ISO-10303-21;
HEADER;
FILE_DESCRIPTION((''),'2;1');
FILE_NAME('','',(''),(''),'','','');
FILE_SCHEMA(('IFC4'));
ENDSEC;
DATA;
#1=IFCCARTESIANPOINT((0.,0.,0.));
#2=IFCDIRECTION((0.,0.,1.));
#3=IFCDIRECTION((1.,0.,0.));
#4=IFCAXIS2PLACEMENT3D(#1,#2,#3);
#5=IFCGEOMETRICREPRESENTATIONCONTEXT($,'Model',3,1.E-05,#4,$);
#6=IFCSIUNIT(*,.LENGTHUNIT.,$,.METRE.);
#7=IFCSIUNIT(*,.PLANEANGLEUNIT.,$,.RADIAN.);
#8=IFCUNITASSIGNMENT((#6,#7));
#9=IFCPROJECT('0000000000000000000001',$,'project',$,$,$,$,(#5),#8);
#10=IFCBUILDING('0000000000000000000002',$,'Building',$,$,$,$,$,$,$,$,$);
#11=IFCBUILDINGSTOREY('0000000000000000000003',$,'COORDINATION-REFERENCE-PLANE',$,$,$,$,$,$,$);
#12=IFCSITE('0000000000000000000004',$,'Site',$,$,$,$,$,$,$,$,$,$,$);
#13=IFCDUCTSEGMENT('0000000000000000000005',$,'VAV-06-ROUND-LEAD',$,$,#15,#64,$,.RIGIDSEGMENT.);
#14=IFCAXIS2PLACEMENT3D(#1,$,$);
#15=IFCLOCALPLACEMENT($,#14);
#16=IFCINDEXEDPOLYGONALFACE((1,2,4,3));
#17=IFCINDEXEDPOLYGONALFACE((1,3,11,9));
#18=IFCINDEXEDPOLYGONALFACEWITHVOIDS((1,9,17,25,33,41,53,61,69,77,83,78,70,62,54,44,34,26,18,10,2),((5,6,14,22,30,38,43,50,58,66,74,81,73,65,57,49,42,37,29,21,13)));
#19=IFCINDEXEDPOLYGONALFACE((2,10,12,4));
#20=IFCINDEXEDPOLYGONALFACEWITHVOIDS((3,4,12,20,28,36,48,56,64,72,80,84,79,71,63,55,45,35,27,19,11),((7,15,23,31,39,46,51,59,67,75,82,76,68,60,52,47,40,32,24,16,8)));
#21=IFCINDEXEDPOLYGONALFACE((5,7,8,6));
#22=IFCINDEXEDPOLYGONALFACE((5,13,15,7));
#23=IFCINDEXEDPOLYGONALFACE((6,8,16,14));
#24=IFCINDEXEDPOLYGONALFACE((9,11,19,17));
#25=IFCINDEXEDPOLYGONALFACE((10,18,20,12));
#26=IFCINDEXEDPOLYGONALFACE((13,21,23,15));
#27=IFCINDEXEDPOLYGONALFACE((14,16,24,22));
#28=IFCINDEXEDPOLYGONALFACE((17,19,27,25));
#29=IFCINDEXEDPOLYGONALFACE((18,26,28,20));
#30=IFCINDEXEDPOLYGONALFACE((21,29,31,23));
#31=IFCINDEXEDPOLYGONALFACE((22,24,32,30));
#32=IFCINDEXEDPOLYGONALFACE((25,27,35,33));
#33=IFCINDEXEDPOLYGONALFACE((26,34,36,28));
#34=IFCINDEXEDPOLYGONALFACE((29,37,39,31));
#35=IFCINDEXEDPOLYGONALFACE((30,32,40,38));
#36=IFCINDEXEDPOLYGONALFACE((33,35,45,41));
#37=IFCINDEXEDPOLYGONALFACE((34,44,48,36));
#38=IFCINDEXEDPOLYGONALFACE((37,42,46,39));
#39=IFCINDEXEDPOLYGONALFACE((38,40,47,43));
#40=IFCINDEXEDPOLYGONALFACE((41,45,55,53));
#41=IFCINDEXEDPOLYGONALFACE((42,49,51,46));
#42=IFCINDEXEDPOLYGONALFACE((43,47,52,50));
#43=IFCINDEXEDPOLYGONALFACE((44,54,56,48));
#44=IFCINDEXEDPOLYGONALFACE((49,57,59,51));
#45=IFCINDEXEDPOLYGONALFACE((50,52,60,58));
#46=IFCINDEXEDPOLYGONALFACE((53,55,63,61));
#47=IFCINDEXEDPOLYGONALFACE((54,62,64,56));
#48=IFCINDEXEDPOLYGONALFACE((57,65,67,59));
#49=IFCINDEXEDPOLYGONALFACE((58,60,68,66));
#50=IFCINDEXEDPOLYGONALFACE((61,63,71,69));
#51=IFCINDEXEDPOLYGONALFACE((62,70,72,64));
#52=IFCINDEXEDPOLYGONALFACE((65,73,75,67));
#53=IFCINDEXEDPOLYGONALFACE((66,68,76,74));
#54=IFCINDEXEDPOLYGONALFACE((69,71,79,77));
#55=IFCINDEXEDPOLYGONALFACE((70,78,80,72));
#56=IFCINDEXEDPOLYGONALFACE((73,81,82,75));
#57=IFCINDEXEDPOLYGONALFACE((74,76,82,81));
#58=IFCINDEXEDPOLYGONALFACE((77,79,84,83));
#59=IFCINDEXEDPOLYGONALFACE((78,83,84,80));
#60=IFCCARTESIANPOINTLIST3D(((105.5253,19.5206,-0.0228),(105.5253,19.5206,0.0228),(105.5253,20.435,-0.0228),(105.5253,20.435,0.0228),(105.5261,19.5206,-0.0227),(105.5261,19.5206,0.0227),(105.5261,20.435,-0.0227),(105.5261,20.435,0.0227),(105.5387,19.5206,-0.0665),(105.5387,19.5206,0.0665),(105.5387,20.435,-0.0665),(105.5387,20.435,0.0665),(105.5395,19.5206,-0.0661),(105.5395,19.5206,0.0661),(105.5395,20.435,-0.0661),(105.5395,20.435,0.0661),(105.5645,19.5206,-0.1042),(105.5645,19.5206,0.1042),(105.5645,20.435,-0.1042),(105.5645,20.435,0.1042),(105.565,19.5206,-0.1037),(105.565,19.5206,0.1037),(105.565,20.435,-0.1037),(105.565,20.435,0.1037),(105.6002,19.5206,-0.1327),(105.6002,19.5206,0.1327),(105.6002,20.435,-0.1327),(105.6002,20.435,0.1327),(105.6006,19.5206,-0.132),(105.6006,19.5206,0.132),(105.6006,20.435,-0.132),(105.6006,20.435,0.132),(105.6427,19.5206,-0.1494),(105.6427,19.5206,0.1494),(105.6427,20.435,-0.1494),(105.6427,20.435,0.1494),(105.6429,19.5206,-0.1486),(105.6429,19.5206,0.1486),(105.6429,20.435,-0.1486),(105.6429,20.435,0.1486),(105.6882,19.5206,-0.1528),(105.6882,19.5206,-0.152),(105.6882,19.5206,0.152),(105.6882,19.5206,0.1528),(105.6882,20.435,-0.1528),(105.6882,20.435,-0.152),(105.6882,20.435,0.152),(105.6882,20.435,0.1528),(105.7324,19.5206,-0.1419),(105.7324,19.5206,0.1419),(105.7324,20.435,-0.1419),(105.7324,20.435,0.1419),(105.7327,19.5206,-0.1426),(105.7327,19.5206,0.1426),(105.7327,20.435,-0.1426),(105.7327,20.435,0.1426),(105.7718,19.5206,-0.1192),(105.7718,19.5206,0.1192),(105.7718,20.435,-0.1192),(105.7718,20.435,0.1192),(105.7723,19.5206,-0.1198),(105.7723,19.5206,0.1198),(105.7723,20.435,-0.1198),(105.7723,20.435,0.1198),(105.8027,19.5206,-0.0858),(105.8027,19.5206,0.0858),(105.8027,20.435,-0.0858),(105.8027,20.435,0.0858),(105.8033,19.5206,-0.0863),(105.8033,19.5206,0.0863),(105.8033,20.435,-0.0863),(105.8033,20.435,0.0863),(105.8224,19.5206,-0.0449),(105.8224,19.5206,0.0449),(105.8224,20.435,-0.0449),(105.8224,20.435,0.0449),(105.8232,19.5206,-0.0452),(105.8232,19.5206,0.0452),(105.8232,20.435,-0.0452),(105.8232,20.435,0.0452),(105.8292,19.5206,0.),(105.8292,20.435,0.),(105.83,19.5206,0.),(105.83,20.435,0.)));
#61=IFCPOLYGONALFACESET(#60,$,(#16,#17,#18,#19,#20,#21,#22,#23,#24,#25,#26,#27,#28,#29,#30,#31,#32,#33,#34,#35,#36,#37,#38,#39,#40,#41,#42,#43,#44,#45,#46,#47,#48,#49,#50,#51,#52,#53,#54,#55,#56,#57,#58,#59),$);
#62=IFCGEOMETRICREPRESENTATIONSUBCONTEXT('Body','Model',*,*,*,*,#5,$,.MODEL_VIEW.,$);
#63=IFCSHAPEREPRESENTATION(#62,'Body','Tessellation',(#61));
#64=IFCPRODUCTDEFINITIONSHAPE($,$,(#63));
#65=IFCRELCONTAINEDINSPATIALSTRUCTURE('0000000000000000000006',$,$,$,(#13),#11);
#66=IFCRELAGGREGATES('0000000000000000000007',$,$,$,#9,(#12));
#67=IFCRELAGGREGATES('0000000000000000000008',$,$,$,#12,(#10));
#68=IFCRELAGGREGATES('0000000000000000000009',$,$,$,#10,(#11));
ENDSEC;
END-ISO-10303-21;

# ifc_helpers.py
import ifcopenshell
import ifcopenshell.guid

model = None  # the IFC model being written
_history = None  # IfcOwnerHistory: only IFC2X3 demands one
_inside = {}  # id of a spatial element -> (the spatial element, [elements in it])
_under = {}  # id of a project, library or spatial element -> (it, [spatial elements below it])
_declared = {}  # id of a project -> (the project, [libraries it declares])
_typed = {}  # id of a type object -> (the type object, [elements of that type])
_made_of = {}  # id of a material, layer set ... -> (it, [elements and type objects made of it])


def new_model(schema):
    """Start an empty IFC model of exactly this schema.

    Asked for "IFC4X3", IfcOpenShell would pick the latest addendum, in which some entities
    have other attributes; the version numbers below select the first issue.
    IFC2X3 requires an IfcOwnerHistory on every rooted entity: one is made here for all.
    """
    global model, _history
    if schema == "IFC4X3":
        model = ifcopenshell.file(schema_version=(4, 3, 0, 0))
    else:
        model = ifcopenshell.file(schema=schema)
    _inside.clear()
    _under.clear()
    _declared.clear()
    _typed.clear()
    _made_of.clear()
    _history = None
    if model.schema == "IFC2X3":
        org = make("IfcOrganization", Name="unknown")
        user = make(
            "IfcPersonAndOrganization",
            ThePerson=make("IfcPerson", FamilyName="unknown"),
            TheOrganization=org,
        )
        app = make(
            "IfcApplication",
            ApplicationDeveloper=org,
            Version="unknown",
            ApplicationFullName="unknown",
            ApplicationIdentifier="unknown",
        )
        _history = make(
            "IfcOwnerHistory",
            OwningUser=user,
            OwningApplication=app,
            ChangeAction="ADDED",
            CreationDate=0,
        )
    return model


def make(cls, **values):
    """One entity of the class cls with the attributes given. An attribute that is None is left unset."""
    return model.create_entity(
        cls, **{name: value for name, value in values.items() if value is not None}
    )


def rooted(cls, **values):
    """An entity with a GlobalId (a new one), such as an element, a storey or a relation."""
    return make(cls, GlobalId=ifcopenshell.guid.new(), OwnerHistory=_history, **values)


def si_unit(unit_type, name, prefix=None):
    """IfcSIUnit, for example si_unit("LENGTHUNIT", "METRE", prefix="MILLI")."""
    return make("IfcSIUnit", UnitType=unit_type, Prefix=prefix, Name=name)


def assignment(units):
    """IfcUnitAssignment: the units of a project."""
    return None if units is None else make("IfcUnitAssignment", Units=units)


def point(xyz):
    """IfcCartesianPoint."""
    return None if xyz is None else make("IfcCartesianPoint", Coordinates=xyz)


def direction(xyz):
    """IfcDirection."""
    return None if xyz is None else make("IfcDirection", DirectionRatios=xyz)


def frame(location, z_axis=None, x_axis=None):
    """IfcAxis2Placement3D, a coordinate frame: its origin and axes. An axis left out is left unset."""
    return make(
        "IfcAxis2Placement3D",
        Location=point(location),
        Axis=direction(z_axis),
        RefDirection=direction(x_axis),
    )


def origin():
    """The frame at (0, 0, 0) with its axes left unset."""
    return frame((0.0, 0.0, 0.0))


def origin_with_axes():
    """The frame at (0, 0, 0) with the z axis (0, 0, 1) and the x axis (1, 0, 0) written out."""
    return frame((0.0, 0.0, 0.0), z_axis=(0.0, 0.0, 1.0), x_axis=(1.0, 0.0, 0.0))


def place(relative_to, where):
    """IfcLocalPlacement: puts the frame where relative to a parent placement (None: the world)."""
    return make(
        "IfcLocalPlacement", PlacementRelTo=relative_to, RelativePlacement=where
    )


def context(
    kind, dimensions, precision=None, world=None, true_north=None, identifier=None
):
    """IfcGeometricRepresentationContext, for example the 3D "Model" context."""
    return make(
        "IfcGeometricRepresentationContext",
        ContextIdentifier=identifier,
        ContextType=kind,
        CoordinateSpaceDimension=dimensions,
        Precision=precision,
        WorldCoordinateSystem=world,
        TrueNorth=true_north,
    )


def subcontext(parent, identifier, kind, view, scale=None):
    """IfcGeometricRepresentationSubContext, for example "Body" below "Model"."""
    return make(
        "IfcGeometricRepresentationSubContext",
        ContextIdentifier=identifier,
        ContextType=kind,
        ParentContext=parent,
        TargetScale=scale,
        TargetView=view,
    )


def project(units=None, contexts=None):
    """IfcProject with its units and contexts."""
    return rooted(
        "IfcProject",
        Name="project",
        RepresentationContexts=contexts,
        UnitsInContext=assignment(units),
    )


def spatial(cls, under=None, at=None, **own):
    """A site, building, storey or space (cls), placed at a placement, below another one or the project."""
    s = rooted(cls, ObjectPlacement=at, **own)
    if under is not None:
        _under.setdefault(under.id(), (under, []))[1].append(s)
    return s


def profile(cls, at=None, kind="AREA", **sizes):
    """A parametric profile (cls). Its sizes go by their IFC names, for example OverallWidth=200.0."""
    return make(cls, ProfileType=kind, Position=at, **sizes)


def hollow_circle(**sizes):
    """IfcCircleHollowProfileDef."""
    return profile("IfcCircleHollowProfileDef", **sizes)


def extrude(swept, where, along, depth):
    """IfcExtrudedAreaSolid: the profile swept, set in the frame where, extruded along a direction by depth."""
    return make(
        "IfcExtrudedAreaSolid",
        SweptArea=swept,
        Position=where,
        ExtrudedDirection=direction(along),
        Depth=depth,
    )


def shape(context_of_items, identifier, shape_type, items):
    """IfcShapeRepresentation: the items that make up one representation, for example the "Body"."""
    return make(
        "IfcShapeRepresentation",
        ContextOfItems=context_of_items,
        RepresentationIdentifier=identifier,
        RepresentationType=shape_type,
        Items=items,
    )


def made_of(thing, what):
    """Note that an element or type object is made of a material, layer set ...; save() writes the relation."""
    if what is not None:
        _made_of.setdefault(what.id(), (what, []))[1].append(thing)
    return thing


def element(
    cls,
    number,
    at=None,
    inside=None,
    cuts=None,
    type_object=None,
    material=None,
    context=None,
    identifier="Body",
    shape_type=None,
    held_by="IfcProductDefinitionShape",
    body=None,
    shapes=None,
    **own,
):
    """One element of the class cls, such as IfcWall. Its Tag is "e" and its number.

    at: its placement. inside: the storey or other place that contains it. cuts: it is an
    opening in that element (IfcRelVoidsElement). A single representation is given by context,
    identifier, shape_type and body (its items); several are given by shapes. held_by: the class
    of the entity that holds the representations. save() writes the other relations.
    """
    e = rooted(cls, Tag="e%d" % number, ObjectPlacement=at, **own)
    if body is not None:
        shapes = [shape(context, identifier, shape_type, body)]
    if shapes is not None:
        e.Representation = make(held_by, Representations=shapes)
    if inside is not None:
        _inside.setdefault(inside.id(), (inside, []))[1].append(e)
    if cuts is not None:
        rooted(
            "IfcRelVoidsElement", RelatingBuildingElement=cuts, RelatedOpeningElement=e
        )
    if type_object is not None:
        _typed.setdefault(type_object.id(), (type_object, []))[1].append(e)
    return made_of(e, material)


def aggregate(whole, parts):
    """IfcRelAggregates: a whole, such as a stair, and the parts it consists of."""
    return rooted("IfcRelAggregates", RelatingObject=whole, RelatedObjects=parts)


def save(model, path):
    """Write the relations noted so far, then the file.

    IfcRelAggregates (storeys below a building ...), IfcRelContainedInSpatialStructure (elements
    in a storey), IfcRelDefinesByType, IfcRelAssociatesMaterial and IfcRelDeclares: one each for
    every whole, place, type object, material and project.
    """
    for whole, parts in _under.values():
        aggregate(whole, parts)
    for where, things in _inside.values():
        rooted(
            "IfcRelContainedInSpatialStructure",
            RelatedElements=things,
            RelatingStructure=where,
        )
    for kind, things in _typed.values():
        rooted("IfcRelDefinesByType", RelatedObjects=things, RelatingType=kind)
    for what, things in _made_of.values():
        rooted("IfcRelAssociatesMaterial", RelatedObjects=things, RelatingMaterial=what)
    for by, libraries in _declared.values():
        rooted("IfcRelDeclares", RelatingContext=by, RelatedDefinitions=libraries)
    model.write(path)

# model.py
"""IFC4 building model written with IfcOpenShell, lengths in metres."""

from ifc_helpers import new_model, si_unit, frame, origin, origin_with_axes, place, context, subcontext, project, spatial, hollow_circle, extrude, element, save


model = new_model("IFC4")

# Units and contexts
model_context_1 = context("Model", 3, precision=1e-05, world=origin_with_axes())
body_context_1 = subcontext(model_context_1, "Body", "Model", "MODEL_VIEW")
ifc_project = project(units=[si_unit("LENGTHUNIT", "METRE"), si_unit("PLANEANGLEUNIT", "RADIAN")], contexts=[model_context_1])

# Site, building, storey
site = spatial("IfcSite", under=ifc_project, Name="Site")
building = spatial("IfcBuilding", under=site, Name="Building")
storey = spatial("IfcBuildingStorey", under=building, Name="COORDINATION-REFERENCE-PLANE")

# Duct segment
duct_segment_1_placement = place(None, frame((105.6768, 20.435, 0.0), z_axis=(0.0, -1.0, 0.0), x_axis=(1.0, 0.0, 0.0)))
element("IfcDuctSegment", 1, at=duct_segment_1_placement, inside=storey, Name="VAV-06-ROUND-LEAD", PredefinedType="RIGIDSEGMENT", context=body_context_1, shape_type="SweptSolid", body=[
    extrude(hollow_circle(Radius=0.1532, WallThickness=0.0008), origin(), (0.0, 0.0, 1.0), 0.9144),
])

save(model, "model.ifc")
